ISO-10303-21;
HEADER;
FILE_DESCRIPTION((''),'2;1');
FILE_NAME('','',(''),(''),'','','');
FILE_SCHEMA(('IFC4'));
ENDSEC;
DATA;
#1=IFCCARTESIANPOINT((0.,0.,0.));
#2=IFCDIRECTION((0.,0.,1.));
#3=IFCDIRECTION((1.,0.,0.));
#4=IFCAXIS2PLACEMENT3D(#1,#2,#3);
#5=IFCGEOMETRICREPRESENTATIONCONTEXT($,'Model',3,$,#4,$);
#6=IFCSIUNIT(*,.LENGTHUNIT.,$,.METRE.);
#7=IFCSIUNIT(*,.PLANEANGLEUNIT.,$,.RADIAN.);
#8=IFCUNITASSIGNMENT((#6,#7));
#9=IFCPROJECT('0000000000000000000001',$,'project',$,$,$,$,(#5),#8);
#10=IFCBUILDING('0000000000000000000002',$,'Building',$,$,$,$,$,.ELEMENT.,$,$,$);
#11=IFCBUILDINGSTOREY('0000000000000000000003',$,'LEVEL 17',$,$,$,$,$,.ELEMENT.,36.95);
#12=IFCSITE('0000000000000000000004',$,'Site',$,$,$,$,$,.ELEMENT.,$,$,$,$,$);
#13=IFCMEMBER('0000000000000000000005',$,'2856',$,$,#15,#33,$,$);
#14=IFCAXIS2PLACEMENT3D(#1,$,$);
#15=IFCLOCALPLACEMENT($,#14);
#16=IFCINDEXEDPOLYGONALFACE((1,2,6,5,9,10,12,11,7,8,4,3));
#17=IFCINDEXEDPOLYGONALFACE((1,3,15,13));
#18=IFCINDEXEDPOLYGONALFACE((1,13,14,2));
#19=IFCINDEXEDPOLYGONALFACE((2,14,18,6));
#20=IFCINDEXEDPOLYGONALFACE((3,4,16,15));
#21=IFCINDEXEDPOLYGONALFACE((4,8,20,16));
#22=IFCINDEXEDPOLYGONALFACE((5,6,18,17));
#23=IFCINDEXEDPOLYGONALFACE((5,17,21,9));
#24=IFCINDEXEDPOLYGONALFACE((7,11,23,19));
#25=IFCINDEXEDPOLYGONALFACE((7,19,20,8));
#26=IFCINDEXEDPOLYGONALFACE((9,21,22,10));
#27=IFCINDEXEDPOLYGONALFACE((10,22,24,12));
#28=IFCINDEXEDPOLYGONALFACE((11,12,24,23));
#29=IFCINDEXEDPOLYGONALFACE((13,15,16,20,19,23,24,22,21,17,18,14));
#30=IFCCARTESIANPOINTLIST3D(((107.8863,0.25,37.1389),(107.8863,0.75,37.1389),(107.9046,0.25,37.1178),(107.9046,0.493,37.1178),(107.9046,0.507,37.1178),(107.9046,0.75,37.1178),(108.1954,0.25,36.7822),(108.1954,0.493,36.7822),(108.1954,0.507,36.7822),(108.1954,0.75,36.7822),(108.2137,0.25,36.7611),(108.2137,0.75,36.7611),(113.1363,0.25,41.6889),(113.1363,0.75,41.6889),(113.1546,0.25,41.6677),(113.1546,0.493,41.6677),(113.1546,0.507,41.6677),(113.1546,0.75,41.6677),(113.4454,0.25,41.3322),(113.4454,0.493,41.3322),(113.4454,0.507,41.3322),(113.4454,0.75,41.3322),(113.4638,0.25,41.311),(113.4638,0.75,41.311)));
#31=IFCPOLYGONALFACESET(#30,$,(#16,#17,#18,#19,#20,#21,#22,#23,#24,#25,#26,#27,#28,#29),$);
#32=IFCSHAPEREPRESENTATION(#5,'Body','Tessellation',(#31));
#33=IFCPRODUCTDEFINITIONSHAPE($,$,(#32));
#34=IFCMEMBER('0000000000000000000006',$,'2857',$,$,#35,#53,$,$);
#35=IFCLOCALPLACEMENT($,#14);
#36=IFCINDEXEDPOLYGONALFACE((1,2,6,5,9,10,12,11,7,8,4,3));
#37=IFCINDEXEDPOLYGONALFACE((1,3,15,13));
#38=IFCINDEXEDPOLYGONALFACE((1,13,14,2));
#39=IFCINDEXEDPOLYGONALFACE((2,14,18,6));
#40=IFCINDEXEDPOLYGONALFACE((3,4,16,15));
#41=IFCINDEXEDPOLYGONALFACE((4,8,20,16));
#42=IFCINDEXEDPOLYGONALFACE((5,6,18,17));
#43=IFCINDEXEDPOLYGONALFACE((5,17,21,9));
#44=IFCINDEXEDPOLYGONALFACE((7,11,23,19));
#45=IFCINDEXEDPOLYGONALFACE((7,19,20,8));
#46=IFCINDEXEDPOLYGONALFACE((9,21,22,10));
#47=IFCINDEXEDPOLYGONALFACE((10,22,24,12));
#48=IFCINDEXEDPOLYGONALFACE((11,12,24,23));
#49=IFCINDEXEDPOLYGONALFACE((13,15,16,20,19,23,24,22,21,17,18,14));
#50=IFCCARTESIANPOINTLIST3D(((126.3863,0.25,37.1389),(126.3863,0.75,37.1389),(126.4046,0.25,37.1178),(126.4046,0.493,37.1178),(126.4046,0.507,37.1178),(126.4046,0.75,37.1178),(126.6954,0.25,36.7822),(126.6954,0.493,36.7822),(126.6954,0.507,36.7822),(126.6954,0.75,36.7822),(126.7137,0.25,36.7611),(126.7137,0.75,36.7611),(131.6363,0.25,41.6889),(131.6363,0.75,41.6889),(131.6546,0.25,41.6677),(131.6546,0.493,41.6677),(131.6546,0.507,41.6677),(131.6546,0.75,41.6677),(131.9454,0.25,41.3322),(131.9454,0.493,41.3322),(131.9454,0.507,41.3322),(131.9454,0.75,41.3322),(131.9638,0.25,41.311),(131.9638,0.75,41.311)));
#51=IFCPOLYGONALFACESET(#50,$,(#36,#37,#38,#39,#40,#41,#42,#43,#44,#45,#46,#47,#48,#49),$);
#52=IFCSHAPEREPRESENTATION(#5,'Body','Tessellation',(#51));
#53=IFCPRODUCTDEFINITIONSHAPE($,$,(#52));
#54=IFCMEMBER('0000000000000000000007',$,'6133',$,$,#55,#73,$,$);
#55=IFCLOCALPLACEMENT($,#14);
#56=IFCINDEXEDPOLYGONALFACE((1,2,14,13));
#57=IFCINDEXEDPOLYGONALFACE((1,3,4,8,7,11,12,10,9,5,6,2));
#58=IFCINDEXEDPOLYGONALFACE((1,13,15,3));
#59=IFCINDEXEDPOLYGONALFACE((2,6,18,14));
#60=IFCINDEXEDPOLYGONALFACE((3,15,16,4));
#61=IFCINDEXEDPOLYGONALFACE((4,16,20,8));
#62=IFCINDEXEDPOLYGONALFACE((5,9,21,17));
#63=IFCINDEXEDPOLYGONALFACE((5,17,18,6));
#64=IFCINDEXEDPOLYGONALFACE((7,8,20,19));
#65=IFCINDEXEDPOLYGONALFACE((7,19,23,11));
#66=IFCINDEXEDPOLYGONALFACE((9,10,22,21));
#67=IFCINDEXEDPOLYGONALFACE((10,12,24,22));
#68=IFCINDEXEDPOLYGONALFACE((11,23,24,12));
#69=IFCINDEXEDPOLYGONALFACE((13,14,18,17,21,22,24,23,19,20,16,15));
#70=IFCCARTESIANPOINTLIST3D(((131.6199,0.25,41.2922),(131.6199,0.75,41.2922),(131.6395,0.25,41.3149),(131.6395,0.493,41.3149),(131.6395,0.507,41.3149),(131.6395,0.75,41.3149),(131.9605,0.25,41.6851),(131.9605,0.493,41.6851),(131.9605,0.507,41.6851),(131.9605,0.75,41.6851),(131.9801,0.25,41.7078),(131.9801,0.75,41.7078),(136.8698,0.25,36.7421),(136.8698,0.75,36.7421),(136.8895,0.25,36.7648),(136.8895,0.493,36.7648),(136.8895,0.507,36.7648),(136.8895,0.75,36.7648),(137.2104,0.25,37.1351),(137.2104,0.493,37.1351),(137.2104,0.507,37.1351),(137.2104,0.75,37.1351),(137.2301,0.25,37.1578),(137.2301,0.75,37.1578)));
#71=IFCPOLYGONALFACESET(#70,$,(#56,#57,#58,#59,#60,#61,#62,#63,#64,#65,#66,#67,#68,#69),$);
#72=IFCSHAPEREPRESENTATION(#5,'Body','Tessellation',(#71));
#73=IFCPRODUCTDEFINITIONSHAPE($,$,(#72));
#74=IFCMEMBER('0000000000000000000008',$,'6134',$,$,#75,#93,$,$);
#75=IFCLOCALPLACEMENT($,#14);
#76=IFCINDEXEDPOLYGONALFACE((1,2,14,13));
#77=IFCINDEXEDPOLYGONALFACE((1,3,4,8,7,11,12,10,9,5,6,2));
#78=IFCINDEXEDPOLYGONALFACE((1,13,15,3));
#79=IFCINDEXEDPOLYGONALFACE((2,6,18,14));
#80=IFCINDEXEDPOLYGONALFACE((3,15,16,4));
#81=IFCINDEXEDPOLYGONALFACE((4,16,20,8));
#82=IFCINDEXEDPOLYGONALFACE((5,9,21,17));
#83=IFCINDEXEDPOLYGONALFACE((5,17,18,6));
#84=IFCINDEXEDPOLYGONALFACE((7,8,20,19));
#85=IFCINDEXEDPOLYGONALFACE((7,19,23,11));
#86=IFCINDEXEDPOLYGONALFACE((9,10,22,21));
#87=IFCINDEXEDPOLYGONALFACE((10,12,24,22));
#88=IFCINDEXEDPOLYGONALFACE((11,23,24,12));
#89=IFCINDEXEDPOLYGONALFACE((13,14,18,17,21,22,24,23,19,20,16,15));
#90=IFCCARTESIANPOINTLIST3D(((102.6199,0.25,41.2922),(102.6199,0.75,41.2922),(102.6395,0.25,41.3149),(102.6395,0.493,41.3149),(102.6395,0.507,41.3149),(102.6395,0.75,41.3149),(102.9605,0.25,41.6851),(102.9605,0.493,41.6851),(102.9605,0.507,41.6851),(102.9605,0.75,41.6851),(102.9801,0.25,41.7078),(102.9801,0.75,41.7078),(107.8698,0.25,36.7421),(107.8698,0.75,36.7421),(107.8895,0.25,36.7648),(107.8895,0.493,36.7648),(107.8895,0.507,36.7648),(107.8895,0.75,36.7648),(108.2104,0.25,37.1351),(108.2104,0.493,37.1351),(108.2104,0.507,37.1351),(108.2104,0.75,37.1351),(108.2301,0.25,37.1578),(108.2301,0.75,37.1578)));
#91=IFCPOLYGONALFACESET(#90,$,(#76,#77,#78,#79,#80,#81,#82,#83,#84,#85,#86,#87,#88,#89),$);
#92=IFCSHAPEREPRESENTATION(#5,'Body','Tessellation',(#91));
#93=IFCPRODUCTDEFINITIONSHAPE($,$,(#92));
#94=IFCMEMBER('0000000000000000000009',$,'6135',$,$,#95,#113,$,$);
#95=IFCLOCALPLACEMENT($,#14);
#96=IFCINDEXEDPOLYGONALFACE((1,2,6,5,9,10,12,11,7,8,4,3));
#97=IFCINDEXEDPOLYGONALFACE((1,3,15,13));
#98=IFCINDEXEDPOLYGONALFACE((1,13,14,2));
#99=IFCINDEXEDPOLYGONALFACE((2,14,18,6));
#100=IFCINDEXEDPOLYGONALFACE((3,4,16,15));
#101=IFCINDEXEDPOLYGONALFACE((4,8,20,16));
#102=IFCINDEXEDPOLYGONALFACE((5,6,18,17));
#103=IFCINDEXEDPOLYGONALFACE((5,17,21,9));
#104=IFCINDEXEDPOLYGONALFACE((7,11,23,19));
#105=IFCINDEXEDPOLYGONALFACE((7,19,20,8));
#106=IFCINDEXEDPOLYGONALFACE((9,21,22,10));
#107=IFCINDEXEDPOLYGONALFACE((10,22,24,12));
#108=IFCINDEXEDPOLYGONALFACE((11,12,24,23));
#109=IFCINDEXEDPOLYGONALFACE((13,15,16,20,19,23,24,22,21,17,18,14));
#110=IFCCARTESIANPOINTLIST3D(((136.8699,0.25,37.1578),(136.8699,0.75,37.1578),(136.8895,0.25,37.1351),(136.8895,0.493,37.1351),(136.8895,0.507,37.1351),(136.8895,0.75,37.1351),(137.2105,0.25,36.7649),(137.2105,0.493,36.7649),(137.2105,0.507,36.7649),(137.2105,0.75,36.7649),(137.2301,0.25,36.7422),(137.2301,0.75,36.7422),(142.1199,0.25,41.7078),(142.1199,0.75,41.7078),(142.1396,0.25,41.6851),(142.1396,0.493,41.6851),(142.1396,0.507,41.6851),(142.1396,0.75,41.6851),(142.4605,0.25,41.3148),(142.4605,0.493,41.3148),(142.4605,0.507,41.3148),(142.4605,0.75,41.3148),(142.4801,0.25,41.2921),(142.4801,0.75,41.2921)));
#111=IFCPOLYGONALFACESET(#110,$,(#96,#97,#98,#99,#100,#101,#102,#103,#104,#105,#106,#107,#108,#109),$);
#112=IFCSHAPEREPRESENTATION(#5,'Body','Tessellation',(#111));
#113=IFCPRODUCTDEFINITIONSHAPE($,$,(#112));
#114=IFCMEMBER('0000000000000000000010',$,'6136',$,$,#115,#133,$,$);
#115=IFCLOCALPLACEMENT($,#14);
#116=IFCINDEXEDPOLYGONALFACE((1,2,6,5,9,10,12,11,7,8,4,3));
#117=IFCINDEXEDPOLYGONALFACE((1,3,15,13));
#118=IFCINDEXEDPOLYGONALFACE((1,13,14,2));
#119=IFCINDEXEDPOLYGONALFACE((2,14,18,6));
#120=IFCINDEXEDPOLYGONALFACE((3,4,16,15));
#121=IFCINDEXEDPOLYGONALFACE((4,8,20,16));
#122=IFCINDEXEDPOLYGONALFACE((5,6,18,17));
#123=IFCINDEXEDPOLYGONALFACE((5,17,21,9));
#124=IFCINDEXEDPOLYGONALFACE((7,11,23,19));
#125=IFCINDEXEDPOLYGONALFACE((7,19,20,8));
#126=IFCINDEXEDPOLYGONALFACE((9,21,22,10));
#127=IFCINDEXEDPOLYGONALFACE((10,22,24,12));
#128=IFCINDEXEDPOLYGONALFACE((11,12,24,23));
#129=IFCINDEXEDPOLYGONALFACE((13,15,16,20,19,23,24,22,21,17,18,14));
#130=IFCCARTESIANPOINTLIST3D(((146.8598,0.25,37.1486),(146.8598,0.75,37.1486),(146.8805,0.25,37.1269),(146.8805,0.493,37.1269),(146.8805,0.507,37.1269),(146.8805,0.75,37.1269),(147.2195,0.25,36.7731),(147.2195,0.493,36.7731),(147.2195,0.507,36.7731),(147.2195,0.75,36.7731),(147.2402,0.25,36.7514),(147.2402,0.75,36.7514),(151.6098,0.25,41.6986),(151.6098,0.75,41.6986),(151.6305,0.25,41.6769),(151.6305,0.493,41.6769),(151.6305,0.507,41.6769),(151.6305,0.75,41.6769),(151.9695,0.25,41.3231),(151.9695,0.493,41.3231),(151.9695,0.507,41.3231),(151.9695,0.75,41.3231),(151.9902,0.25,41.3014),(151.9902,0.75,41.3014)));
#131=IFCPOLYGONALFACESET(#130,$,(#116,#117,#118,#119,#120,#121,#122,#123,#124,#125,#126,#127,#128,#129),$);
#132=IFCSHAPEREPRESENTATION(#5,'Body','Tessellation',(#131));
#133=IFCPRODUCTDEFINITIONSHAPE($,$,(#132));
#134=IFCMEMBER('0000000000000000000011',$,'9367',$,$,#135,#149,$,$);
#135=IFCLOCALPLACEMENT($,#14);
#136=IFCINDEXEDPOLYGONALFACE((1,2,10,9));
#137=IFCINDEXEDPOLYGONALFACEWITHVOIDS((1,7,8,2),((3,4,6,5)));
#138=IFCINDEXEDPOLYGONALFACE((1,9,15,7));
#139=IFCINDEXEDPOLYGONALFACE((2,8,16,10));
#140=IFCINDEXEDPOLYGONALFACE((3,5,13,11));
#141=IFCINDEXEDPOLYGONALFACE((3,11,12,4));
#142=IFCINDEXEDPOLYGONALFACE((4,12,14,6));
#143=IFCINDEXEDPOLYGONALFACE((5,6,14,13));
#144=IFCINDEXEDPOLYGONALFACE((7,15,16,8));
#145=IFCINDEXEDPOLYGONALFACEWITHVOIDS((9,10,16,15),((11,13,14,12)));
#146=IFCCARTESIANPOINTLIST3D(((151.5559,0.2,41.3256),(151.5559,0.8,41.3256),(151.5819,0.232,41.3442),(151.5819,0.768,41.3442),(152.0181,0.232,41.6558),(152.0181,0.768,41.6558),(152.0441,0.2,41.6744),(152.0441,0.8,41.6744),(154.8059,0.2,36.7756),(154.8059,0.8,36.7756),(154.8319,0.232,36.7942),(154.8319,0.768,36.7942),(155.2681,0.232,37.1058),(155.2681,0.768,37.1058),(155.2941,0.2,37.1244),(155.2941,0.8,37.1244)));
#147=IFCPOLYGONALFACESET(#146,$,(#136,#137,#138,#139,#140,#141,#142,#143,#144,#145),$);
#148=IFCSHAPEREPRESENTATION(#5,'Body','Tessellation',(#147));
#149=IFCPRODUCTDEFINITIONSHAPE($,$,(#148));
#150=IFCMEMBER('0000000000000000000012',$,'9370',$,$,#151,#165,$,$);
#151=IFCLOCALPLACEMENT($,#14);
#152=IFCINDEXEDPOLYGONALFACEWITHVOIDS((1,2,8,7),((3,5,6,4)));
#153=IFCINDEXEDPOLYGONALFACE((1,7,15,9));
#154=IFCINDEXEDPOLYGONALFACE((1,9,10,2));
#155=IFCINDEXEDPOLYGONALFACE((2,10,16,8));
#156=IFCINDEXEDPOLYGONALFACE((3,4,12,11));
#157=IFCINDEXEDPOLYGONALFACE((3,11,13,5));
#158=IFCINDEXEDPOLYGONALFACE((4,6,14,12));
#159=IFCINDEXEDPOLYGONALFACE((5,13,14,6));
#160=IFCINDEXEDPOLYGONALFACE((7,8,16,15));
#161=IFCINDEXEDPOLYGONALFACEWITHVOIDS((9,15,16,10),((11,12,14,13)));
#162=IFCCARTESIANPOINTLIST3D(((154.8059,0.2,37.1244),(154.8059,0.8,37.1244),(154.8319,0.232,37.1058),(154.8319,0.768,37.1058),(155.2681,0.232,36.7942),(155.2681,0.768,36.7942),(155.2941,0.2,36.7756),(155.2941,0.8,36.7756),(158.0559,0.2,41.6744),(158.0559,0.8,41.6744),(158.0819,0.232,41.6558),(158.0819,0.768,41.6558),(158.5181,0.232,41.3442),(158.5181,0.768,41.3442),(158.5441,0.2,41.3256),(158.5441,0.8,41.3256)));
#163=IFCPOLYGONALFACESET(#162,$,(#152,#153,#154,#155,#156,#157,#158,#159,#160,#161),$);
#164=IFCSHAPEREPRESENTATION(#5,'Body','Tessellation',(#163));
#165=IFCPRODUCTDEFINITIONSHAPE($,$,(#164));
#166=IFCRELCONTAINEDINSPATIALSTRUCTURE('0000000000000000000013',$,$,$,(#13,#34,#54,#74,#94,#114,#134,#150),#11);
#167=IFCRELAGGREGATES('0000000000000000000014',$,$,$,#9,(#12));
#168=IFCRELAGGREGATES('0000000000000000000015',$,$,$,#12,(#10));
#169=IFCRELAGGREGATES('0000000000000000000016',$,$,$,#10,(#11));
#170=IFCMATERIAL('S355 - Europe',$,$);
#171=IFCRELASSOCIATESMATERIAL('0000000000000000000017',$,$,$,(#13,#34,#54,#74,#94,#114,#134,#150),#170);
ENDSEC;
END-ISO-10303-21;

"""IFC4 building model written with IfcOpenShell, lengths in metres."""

from ifc_helpers import new_model, si_unit, frame, origin_with_axes, origin_2d_with_axis, place, context, project, spatial, hollow_rectangle, i_section, extrude, material, material_profile, profile_set, profile_usage, element, save


model = new_model("IFC4")

# Units and contexts
model_context = context("Model", 3, world=origin_with_axes())
ifc_project = project(units=[si_unit("LENGTHUNIT", "METRE"), si_unit("PLANEANGLEUNIT", "RADIAN")], contexts=[model_context])

# Site, building, storey
site = spatial("IfcSite", under=ifc_project, Name="Site", CompositionType="ELEMENT")
building = spatial("IfcBuilding", under=site, Name="Building", CompositionType="ELEMENT")
storey = spatial("IfcBuildingStorey", under=building, Name="LEVEL 17", CompositionType="ELEMENT", Elevation=36.95)

# Shared definitions
ifc_material = material(Name="S355 - Europe")

# Members
ifc_material_profile_1 = material_profile(ifc_material, i_section(OverallWidth=0.5, OverallDepth=0.5, WebThickness=0.014, FlangeThickness=0.028, at=origin_2d_with_axis()))
ifc_profile_set_1 = profile_set([ifc_material_profile_1])
ifc_profile_usage_1 = profile_usage(ifc_profile_set_1, cardinal=10)
member_1_placement = place(None, frame((108.05, 0.5, 36.95), z_axis=(0.755695, 0.0, 0.654923), x_axis=(0.0, 1.0, 0.0)))
element("IfcMember", 1, at=member_1_placement, inside=storey, material=ifc_profile_usage_1, Name="2856", context=model_context, shape_type="SweptSolid", body=[
    extrude(i_section(OverallWidth=0.5, OverallDepth=0.5, WebThickness=0.014, FlangeThickness=0.028, at=origin_2d_with_axis()), origin_with_axes(), (0.0, 0.0, 1.0), 6.9473),
])
ifc_material_profile_2 = material_profile(ifc_material, i_section(OverallWidth=0.5, OverallDepth=0.5, WebThickness=0.014, FlangeThickness=0.028, at=origin_2d_with_axis()))
ifc_profile_set_2 = profile_set([ifc_material_profile_2])
ifc_profile_usage_2 = profile_usage(ifc_profile_set_2, cardinal=10)
member_2_placement = place(None, frame((126.55, 0.5, 36.95), z_axis=(0.755695, 0.0, 0.654923), x_axis=(0.0, 1.0, 0.0)))
element("IfcMember", 2, at=member_2_placement, inside=storey, material=ifc_profile_usage_2, Name="2857", context=model_context, shape_type="SweptSolid", body=[
    extrude(i_section(OverallWidth=0.5, OverallDepth=0.5, WebThickness=0.014, FlangeThickness=0.028, at=origin_2d_with_axis()), origin_with_axes(), (0.0, 0.0, 1.0), 6.9473),
])
ifc_material_profile_3 = material_profile(ifc_material, i_section(OverallWidth=0.5, OverallDepth=0.55, WebThickness=0.014, FlangeThickness=0.03, at=origin_2d_with_axis()))
ifc_profile_set_3 = profile_set([ifc_material_profile_3])
ifc_profile_usage_3 = profile_usage(ifc_profile_set_3, cardinal=10)
member_3_placement = place(None, frame((131.8, 0.5, 41.5), z_axis=(0.755683, 0.0, -0.654938), x_axis=(0.0, 1.0, 0.0)))
element("IfcMember", 3, at=member_3_placement, inside=storey, material=ifc_profile_usage_3, Name="6133", context=model_context, shape_type="SweptSolid", body=[
    extrude(i_section(OverallWidth=0.5, OverallDepth=0.55, WebThickness=0.014, FlangeThickness=0.03, at=origin_2d_with_axis()), origin_with_axes(), (0.0, 0.0, 1.0), 6.9473),
])
ifc_material_profile_4 = material_profile(ifc_material, i_section(OverallWidth=0.5, OverallDepth=0.55, WebThickness=0.014, FlangeThickness=0.03, at=origin_2d_with_axis()))
ifc_profile_set_4 = profile_set([ifc_material_profile_4])
ifc_profile_usage_4 = profile_usage(ifc_profile_set_4, cardinal=10)
member_4_placement = place(None, frame((102.8, 0.5, 41.5), z_axis=(0.755683, 0.0, -0.654938), x_axis=(0.0, 1.0, 0.0)))
element("IfcMember", 4, at=member_4_placement, inside=storey, material=ifc_profile_usage_4, Name="6134", context=model_context, shape_type="SweptSolid", body=[
    extrude(i_section(OverallWidth=0.5, OverallDepth=0.55, WebThickness=0.014, FlangeThickness=0.03, at=origin_2d_with_axis()), origin_with_axes(), (0.0, 0.0, 1.0), 6.9473),
])
ifc_material_profile_5 = material_profile(ifc_material, i_section(OverallWidth=0.5, OverallDepth=0.55, WebThickness=0.014, FlangeThickness=0.03, at=origin_2d_with_axis()))
ifc_profile_set_5 = profile_set([ifc_material_profile_5])
ifc_profile_usage_5 = profile_usage(ifc_profile_set_5, cardinal=10)
member_5_placement = place(None, frame((137.05, 0.5, 36.95), z_axis=(0.755695, 0.0, 0.654923), x_axis=(0.0, 1.0, 0.0)))
element("IfcMember", 5, at=member_5_placement, inside=storey, material=ifc_profile_usage_5, Name="6135", context=model_context, shape_type="SweptSolid", body=[
    extrude(i_section(OverallWidth=0.5, OverallDepth=0.55, WebThickness=0.014, FlangeThickness=0.03, at=origin_2d_with_axis()), origin_with_axes(), (0.0, 0.0, 1.0), 6.9473),
])
ifc_material_profile_6 = material_profile(ifc_material, i_section(OverallWidth=0.5, OverallDepth=0.55, WebThickness=0.014, FlangeThickness=0.03, at=origin_2d_with_axis()))
ifc_profile_set_6 = profile_set([ifc_material_profile_6])
ifc_profile_usage_6 = profile_usage(ifc_profile_set_6, cardinal=10)
member_6_placement = place(None, frame((147.05, 0.5, 36.95), z_axis=(0.722146, 0.0, 0.69174), x_axis=(0.0, 1.0, 0.0)))
element("IfcMember", 6, at=member_6_placement, inside=storey, material=ifc_profile_usage_6, Name="6136", context=model_context, shape_type="SweptSolid", body=[
    extrude(i_section(OverallWidth=0.5, OverallDepth=0.55, WebThickness=0.014, FlangeThickness=0.03, at=origin_2d_with_axis()), origin_with_axes(), (0.0, 0.0, 1.0), 6.5776),
])
ifc_material_profile_7 = material_profile(ifc_material, hollow_rectangle(XDim=0.6, YDim=0.6, WallThickness=0.032, at=origin_2d_with_axis()))
ifc_profile_set_7 = profile_set([ifc_material_profile_7])
ifc_profile_usage_7 = profile_usage(ifc_profile_set_7, cardinal=10)
member_7_placement = place(None, frame((151.8, 0.5, 41.5), z_axis=(0.581238, 0.0, -0.813733), x_axis=(0.0, 1.0, 0.0)))
element("IfcMember", 7, at=member_7_placement, inside=storey, material=ifc_profile_usage_7, Name="9367", context=model_context, shape_type="SweptSolid", body=[
    extrude(hollow_rectangle(XDim=0.6, YDim=0.6, WallThickness=0.032, at=origin_2d_with_axis()), origin_with_axes(), (0.0, 0.0, 1.0), 5.5915),
])
ifc_material_profile_8 = material_profile(ifc_material, hollow_rectangle(XDim=0.6, YDim=0.6, WallThickness=0.032, at=origin_2d_with_axis()))
ifc_profile_set_8 = profile_set([ifc_material_profile_8])
ifc_profile_usage_8 = profile_usage(ifc_profile_set_8, cardinal=10)
member_8_placement = place(None, frame((155.05, 0.5, 36.95), z_axis=(0.581238, 0.0, 0.813733), x_axis=(0.0, 1.0, 0.0)))
element("IfcMember", 8, at=member_8_placement, inside=storey, material=ifc_profile_usage_8, Name="9370", context=model_context, shape_type="SweptSolid", body=[
    extrude(hollow_rectangle(XDim=0.6, YDim=0.6, WallThickness=0.032, at=origin_2d_with_axis()), origin_with_axes(), (0.0, 0.0, 1.0), 5.5915),
])

save(model, "model.ifc")
